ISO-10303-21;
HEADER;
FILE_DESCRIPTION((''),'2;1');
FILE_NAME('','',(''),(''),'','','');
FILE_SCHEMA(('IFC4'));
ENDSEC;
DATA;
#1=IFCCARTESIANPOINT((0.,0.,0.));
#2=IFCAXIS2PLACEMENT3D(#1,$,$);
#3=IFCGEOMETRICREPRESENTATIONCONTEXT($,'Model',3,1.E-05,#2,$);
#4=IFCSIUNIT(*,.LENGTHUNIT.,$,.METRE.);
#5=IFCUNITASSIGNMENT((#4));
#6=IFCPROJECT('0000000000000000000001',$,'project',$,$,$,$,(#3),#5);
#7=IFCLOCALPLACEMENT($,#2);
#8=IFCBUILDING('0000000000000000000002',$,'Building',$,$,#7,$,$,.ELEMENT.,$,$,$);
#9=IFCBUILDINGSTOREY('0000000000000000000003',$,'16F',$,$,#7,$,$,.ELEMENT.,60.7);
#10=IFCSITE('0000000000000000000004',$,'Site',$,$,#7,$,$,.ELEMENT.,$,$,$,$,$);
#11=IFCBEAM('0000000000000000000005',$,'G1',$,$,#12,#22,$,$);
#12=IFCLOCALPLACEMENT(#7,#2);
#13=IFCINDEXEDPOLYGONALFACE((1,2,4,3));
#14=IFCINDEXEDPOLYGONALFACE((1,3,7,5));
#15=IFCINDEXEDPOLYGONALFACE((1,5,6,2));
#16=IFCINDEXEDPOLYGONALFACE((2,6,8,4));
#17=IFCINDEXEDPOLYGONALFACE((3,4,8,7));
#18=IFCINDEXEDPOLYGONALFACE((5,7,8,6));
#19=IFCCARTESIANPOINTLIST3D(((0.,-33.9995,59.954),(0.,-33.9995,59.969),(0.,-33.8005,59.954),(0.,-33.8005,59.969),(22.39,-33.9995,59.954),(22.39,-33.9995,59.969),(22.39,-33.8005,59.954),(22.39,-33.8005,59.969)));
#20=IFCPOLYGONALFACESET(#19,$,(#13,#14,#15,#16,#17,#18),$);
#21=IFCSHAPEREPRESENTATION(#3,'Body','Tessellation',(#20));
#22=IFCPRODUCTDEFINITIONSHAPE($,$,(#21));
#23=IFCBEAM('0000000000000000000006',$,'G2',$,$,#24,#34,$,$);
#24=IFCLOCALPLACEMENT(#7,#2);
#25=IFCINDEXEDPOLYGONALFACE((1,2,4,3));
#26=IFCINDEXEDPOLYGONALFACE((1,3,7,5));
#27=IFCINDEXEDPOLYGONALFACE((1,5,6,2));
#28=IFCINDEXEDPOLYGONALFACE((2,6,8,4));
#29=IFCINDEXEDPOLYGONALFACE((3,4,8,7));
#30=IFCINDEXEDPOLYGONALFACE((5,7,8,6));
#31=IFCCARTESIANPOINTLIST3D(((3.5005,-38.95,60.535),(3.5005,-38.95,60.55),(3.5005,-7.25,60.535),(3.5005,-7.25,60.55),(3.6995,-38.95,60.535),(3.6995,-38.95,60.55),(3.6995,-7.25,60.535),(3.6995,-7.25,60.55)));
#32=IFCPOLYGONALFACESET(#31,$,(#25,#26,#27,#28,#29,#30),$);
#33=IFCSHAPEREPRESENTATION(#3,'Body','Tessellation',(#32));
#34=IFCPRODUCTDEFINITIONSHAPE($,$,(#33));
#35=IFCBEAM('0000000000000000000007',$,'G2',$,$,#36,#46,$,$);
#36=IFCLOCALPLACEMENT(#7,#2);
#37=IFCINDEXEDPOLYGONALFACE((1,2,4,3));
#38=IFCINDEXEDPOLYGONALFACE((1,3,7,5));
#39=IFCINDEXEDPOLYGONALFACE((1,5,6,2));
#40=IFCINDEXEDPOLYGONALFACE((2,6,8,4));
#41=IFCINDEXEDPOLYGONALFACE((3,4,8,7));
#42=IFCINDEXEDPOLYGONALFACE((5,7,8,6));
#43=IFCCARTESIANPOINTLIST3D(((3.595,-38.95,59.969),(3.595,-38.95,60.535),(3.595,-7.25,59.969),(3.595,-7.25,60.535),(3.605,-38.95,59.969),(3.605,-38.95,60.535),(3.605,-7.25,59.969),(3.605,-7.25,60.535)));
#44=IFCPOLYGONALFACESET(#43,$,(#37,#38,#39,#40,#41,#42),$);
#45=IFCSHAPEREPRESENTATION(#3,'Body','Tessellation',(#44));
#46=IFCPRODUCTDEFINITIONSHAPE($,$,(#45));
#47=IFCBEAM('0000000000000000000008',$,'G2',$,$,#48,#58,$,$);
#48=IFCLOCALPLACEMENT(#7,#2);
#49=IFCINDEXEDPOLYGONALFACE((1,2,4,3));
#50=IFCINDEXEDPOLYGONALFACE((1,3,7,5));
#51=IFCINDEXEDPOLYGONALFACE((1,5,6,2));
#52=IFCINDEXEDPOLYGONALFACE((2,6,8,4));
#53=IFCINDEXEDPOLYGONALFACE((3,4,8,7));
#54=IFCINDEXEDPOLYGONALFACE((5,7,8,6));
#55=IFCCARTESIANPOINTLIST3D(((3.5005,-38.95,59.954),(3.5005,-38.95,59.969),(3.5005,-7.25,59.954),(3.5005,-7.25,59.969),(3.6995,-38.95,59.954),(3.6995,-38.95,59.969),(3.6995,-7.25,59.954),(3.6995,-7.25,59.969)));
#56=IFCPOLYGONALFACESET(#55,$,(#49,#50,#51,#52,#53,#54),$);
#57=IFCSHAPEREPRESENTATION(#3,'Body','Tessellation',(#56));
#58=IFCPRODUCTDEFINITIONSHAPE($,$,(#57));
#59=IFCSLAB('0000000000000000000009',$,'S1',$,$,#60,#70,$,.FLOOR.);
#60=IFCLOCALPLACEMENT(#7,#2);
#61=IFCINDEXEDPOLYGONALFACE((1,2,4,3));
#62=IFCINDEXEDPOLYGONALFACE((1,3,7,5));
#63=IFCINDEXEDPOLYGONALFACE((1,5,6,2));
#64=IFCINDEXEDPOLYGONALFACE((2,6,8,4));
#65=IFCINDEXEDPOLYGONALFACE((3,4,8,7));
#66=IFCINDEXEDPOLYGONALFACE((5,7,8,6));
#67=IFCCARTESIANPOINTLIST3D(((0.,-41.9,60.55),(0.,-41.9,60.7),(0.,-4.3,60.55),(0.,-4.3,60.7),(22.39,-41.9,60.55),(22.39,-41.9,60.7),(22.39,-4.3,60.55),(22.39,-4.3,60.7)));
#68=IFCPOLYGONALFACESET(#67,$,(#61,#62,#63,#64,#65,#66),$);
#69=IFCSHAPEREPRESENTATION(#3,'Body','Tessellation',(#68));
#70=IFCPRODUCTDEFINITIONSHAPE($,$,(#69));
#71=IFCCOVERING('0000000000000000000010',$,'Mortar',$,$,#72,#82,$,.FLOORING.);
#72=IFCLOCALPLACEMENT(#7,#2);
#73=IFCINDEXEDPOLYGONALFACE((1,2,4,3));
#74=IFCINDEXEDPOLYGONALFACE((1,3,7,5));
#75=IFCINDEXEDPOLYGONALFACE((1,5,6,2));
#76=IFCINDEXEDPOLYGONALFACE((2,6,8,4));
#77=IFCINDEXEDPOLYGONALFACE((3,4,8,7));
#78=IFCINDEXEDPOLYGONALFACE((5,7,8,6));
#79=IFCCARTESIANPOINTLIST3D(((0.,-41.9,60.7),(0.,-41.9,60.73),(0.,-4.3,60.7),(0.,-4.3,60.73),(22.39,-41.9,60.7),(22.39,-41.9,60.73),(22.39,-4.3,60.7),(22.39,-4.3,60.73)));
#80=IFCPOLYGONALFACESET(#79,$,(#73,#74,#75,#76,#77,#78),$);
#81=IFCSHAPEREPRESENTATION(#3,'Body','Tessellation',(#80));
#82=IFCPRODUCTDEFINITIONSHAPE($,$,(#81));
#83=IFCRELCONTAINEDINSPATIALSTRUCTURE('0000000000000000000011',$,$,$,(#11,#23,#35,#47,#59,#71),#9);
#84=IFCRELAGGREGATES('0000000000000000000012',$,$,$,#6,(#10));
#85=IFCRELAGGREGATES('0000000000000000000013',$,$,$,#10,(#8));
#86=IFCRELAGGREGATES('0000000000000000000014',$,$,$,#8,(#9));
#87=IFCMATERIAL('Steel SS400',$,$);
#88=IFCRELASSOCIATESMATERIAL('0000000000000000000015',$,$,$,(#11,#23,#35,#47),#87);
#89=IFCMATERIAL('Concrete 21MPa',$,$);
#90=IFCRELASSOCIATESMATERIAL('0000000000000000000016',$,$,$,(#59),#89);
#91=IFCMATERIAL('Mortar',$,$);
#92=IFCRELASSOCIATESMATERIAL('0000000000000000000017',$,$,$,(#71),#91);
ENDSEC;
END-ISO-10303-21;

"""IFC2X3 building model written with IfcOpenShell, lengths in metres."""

from ifc_helpers import new_model, si_unit, frame, origin, origin_2d, place, context, project, spatial, rectangle, extrude, material, element, save


model = new_model("IFC2X3")

# Units and contexts
model_context = context("Model", 3, precision=1e-05, world=origin())
ifc_project = project(units=[si_unit("LENGTHUNIT", "METRE")], contexts=[model_context])

# Site, building, storey
placement = place(None, origin())
site = spatial("IfcSite", under=ifc_project, at=placement, Name="Site", CompositionType="ELEMENT")
building = spatial("IfcBuilding", under=site, at=placement, Name="Building", CompositionType="ELEMENT")
storey = spatial("IfcBuildingStorey", under=building, at=placement, Name="16F", CompositionType="ELEMENT", Elevation=60.7)

# Shared definitions
ifc_material_1 = material(Name="Concrete 21MPa")
ifc_material_2 = material(Name="Steel SS400")

# Beams
beam_1_placement = place(None, frame((11.195, -33.9, 59.954)))
element("IfcBeam", 1, at=beam_1_placement, inside=storey, material=ifc_material_2, Name="G1", context=model_context, shape_type="SweptSolid", body=[
    extrude(rectangle(XDim=22.39, YDim=0.199, at=origin_2d()), origin(), (0.0, 0.0, 1.0), 0.015),
])
beam_2_placement = place(None, frame((3.6, -23.1, 60.535)))
element("IfcBeam", 2, at=beam_2_placement, inside=storey, material=ifc_material_2, Name="G2", context=model_context, shape_type="SweptSolid", body=[
    extrude(rectangle(XDim=0.199, YDim=31.7, at=origin_2d()), origin(), (0.0, 0.0, 1.0), 0.015),
])
beam_3_placement = place(None, frame((3.6, -23.1, 59.969)))
element("IfcBeam", 3, at=beam_3_placement, inside=storey, material=ifc_material_2, Name="G2", context=model_context, shape_type="SweptSolid", body=[
    extrude(rectangle(XDim=0.01, YDim=31.7, at=origin_2d()), origin(), (0.0, 0.0, 1.0), 0.566),
])
beam_4_placement = place(None, frame((3.6, -23.1, 59.954)))
element("IfcBeam", 4, at=beam_4_placement, inside=storey, material=ifc_material_2, Name="G2", context=model_context, shape_type="SweptSolid", body=[
    extrude(rectangle(XDim=0.199, YDim=31.7, at=origin_2d()), origin(), (0.0, 0.0, 1.0), 0.015),
])

# Slab
slab_placement = place(None, frame((11.195, -23.1, 60.55)))
element("IfcSlab", 5, at=slab_placement, inside=storey, material=ifc_material_1, Name="S1", PredefinedType="FLOOR", context=model_context, shape_type="SweptSolid", body=[
    extrude(rectangle(XDim=22.39, YDim=37.6, at=origin_2d()), origin(), (0.0, 0.0, 1.0), 0.15),
])

# Covering
ifc_material_3 = material(Name="Mortar")
covering_placement = place(None, frame((11.195, -23.1, 60.7)))
element("IfcCovering", 6, at=covering_placement, inside=storey, material=ifc_material_3, Name="Mortar", PredefinedType="FLOORING", context=model_context, shape_type="SweptSolid", body=[
    extrude(rectangle(XDim=22.39, YDim=37.6, at=origin_2d()), origin(), (0.0, 0.0, 1.0), 0.03),
])

save(model, "model.ifc")
